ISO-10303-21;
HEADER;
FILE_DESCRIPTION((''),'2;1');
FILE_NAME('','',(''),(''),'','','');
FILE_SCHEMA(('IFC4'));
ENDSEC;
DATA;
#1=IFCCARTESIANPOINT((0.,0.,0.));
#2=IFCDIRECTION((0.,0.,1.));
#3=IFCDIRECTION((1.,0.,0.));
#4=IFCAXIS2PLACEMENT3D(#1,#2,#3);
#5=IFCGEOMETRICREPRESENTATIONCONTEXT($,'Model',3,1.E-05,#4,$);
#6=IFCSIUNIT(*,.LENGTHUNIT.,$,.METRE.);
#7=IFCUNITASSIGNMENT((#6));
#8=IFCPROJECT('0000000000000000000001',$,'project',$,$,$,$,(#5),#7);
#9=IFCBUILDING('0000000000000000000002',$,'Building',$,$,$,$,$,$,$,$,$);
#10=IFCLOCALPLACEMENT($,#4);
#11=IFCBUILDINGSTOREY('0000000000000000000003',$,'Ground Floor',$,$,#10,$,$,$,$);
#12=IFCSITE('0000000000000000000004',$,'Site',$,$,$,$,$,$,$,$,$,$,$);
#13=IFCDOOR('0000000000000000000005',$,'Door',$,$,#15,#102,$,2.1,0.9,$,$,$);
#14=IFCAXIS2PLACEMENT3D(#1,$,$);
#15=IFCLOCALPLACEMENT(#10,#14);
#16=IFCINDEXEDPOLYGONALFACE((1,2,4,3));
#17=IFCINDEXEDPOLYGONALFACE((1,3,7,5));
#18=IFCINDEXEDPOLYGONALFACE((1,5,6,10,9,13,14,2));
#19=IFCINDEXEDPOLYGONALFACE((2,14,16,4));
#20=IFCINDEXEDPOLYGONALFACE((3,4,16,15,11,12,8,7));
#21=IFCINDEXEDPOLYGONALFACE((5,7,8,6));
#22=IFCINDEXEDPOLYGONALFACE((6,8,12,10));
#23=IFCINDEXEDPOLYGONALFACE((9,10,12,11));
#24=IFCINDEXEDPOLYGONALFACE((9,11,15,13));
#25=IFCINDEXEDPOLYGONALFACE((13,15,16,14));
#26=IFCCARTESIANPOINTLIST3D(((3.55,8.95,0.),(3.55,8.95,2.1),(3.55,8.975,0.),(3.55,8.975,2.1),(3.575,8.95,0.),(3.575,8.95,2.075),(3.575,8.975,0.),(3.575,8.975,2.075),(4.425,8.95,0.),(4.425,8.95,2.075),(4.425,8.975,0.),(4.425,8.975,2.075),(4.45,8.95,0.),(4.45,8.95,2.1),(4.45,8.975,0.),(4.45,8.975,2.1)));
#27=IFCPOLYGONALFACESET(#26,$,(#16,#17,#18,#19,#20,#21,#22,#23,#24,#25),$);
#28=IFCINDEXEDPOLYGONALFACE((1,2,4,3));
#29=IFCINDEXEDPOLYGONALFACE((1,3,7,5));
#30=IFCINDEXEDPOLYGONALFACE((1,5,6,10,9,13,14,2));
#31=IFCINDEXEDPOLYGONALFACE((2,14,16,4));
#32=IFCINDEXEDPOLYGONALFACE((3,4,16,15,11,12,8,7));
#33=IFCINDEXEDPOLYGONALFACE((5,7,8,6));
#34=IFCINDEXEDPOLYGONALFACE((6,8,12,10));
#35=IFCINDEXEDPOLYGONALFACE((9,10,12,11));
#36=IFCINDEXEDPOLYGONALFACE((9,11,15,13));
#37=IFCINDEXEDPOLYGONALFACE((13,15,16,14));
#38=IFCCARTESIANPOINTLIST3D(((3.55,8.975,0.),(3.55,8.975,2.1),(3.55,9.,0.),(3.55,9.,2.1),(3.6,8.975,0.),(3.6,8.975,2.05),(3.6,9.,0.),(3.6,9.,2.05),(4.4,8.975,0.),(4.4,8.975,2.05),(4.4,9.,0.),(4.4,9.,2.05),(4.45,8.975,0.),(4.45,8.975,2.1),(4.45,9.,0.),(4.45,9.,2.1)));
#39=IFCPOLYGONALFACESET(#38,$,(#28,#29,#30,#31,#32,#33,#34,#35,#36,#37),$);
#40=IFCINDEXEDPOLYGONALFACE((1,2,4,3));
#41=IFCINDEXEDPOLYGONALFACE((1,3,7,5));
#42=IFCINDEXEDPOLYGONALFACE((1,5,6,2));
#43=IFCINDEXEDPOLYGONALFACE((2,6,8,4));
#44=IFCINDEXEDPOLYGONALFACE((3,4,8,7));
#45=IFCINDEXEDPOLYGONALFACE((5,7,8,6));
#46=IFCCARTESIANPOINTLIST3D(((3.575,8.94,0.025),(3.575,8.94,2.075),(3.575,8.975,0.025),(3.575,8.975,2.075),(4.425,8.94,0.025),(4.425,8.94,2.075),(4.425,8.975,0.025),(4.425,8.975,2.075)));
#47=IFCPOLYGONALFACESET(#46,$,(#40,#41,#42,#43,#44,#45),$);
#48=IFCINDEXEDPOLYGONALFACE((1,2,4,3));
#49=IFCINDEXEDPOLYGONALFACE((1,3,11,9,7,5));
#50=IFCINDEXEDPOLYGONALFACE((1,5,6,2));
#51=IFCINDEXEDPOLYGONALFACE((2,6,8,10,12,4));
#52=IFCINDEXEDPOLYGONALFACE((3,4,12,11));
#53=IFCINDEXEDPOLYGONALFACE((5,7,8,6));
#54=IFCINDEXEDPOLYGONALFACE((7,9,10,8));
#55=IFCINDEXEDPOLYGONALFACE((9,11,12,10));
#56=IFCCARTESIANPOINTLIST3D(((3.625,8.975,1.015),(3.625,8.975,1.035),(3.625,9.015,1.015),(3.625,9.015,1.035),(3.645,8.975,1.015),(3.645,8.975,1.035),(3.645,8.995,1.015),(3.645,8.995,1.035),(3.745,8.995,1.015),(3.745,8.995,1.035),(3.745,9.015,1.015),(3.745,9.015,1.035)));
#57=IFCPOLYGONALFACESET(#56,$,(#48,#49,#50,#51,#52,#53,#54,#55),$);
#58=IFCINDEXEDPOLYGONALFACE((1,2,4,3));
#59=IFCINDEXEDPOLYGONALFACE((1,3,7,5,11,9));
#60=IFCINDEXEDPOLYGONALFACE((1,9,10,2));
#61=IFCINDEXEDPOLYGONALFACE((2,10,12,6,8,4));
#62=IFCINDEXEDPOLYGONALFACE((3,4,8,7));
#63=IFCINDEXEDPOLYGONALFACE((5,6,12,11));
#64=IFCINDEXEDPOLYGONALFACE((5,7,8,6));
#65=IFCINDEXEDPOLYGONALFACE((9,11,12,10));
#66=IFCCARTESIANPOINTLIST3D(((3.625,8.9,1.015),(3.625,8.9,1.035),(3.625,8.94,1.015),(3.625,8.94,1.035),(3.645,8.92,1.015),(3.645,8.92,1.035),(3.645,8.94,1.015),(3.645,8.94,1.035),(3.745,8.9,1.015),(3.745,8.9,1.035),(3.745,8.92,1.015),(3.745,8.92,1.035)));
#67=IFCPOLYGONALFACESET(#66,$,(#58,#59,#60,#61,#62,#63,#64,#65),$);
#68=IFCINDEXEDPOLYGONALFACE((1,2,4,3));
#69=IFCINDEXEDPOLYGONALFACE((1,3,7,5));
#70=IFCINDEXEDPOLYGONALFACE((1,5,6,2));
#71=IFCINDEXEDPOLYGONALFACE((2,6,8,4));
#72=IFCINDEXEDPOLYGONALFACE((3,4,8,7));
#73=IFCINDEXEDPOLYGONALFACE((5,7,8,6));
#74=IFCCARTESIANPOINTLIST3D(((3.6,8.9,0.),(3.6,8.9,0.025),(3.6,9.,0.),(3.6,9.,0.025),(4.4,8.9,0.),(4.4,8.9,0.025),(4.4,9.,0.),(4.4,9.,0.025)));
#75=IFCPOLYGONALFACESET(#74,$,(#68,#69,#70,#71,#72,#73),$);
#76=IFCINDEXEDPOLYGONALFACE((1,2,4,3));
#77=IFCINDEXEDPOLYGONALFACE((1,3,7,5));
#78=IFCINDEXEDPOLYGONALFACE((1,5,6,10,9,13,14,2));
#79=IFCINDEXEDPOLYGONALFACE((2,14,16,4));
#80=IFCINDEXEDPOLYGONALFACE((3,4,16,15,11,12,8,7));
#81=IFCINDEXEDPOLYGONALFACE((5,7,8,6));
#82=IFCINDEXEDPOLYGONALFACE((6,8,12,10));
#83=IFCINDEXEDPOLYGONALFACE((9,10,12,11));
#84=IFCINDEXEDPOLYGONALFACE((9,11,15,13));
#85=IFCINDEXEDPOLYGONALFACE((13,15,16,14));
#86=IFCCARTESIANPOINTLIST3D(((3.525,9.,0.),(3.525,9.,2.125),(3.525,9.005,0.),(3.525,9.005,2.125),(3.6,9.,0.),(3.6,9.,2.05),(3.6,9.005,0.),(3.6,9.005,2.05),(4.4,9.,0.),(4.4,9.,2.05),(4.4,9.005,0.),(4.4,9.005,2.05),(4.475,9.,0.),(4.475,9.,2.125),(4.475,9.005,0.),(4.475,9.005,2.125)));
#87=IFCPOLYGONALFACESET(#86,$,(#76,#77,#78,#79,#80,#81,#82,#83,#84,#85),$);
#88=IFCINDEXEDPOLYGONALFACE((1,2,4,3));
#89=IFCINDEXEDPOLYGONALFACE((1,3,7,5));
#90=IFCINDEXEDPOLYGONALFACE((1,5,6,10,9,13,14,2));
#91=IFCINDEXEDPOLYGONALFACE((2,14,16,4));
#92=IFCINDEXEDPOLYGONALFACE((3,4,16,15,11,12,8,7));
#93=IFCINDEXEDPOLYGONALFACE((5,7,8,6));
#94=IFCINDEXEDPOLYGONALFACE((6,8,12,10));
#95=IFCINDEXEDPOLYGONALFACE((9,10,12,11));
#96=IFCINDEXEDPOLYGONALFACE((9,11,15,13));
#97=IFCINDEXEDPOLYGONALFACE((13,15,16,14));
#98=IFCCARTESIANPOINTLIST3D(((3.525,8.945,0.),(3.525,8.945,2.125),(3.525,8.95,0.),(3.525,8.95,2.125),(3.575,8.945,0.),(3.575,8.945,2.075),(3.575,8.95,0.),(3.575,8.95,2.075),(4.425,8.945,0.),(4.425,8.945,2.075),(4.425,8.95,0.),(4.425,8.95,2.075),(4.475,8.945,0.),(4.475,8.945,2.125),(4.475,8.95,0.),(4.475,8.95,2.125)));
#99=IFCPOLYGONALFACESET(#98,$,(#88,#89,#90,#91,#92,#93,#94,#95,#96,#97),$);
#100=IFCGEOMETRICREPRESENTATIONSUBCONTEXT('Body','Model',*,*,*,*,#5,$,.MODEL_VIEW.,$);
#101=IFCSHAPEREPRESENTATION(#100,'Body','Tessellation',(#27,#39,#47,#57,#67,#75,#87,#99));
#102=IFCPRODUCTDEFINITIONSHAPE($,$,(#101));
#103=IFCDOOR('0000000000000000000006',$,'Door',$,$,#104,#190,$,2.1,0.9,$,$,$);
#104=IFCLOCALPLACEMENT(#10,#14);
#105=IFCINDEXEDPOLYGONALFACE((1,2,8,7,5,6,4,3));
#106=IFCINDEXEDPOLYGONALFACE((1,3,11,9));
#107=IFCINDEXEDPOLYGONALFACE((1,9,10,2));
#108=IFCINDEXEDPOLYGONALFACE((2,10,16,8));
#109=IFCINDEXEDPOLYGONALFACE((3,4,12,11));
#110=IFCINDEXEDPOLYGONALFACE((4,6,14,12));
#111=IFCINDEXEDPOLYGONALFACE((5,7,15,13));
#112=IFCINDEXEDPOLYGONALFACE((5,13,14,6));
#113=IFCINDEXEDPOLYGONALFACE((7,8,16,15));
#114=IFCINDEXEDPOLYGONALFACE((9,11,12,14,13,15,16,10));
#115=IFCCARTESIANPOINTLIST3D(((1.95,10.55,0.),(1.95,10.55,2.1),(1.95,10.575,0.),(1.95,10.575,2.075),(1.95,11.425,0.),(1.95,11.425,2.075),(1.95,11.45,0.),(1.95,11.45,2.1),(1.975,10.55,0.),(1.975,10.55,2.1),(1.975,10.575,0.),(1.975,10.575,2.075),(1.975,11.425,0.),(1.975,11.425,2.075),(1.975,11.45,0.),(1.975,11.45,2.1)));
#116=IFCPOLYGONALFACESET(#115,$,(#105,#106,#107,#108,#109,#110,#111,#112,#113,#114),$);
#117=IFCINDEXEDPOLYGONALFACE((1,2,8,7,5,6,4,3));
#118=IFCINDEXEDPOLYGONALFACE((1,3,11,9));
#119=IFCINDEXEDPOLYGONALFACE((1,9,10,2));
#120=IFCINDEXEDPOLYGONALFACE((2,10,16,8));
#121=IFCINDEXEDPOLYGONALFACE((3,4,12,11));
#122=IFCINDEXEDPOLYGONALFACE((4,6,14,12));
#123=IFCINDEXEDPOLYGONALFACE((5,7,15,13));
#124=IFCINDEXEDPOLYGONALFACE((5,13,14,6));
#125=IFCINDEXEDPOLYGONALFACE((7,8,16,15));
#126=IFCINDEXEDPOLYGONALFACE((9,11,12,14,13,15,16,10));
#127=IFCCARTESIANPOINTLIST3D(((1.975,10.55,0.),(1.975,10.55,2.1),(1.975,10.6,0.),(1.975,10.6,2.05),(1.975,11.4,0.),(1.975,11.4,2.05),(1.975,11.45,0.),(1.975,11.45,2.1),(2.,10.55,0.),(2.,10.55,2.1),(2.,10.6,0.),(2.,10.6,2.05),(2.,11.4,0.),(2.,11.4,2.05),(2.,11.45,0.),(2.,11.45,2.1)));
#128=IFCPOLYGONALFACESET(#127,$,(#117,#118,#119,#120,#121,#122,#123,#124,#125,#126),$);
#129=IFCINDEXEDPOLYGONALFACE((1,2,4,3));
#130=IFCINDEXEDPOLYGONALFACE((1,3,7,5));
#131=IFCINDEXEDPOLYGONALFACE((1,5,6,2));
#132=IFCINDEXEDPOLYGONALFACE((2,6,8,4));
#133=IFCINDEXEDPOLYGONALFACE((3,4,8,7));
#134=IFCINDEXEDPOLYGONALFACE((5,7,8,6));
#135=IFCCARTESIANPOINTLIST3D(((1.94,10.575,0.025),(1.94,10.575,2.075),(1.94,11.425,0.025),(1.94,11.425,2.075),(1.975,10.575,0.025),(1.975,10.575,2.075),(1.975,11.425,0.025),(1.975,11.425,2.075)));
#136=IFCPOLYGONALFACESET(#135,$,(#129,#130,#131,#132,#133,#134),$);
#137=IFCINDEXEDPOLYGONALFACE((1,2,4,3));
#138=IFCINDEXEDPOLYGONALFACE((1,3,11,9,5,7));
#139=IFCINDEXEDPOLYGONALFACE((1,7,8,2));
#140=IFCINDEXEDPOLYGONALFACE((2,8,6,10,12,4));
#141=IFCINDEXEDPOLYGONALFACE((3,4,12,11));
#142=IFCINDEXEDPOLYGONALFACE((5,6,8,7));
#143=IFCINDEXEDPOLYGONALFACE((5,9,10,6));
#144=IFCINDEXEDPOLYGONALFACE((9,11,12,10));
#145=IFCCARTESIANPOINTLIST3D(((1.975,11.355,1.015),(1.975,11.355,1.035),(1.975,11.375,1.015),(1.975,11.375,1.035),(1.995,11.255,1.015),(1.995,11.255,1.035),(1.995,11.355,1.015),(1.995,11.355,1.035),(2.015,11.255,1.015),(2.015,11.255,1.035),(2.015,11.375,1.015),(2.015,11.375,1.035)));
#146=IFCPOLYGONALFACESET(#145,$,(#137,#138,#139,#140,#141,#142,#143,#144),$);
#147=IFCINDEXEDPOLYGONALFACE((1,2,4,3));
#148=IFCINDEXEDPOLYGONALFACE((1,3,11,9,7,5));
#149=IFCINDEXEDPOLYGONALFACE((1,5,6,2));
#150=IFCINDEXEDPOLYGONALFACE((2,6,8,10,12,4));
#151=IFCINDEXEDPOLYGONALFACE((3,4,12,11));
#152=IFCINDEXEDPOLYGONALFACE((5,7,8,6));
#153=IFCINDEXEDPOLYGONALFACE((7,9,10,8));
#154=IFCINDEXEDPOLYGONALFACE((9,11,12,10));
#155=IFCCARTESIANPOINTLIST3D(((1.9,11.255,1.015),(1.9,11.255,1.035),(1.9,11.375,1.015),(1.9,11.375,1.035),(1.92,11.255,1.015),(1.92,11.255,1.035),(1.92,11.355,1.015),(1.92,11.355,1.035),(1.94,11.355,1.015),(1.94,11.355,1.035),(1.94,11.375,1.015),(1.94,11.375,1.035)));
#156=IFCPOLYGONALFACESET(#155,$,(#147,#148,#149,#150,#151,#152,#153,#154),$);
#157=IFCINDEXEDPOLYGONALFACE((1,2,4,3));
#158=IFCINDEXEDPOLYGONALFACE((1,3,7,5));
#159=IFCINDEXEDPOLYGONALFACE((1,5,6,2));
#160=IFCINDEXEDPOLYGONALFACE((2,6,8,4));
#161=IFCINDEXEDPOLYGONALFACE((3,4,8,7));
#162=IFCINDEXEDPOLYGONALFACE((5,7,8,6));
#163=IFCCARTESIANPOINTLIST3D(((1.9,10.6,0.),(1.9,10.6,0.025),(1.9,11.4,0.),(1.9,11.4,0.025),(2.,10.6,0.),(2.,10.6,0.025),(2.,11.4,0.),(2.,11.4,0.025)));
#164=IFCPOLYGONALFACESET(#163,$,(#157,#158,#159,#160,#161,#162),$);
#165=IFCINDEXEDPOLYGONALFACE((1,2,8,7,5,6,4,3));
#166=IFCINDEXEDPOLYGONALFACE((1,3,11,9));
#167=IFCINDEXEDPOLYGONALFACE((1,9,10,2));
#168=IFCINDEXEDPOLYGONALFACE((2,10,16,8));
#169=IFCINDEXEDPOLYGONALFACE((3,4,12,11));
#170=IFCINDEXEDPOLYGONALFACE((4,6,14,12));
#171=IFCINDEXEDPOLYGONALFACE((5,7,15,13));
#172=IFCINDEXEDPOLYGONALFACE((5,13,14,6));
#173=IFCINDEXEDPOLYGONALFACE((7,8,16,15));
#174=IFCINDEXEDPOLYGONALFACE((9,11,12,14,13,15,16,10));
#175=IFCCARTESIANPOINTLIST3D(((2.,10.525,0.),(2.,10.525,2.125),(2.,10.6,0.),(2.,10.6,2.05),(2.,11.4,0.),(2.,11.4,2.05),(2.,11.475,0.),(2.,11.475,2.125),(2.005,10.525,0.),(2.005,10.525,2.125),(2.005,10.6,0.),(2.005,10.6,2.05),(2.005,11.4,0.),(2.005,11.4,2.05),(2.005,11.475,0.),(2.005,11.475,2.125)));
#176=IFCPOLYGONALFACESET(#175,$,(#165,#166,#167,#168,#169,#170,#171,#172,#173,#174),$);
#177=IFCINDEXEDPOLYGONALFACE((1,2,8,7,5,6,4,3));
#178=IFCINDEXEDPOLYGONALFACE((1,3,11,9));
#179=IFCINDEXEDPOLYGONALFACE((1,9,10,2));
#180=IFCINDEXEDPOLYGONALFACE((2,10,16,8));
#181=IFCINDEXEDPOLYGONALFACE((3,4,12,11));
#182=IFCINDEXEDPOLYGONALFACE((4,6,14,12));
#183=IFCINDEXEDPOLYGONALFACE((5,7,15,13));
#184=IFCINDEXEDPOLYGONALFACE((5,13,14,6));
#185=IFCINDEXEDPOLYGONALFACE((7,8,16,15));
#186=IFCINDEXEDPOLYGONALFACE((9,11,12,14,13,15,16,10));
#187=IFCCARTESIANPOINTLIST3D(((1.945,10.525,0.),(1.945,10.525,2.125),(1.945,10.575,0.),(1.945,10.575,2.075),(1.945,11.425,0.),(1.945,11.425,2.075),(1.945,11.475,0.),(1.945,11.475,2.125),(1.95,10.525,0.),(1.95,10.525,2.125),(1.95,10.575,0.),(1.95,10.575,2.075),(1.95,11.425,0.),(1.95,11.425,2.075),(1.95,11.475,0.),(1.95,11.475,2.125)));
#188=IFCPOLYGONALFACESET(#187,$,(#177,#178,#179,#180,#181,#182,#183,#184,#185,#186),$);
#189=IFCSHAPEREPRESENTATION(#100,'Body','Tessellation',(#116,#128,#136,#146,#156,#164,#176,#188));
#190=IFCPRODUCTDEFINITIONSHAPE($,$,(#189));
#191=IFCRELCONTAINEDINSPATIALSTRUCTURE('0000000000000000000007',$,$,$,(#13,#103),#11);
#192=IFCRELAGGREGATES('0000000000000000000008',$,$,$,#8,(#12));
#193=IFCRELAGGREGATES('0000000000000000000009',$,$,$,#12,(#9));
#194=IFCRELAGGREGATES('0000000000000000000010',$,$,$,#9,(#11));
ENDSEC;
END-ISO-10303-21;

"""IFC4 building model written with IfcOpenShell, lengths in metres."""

from ifc_helpers import new_model, si_unit, frame, origin_with_axes, place, context, subcontext, project, spatial, line, indexed_curve, outline, extrude, element, save


model = new_model("IFC4")

# Units and contexts
model_context = context("Model", 3, precision=1e-05, world=origin_with_axes())
body_context = subcontext(model_context, "Body", "Model", "MODEL_VIEW")
ifc_project = project(units=[si_unit("LENGTHUNIT", "METRE")], contexts=[model_context])

# Site, building, storey
site = spatial("IfcSite", under=ifc_project, Name="Site")
building = spatial("IfcBuilding", under=site, Name="Building")
storey_placement = place(None, origin_with_axes())
storey = spatial("IfcBuildingStorey", under=building, at=storey_placement, Name="Ground Floor")

# Doors
door_1_placement = place(storey_placement, frame((4.45, 9.0, 0.0), z_axis=(0.0, 0.0, 1.0), x_axis=(-1.0, 0.0, 0.0)))
element("IfcDoor", 1, at=door_1_placement, inside=storey, Name="Door", OverallHeight=2.1, OverallWidth=0.9, context=body_context, shape_type="SweptSolid", body=[
    extrude(outline(indexed_curve([(0.0, 0.0), (0.0, 2.1), (0.9, 2.1), (0.9, 0.0), (0.875, 0.0), (0.875, 2.075), (0.025, 2.075), (0.025, 0.0)], segments=[line(1, 2, 3, 4, 5, 6, 7, 8, 1)])), frame((0.0, 0.025, 0.0), z_axis=(0.0, -1.0, 0.0), x_axis=(1.0, 0.0, 0.0)), (0.0, 0.0, -1.0), 0.025),
    extrude(outline(indexed_curve([(0.0, 0.0), (0.0, 2.1), (0.9, 2.1), (0.9, 0.0), (0.85, 0.0), (0.85, 2.05), (0.05, 2.05), (0.05, 0.0)], segments=[line(1, 2, 3, 4, 5, 6, 7, 8, 1)])), frame((0.0, 0.0, 0.0), z_axis=(0.0, -1.0, 0.0), x_axis=(1.0, 0.0, 0.0)), (0.0, 0.0, -1.0), 0.025),
    extrude(outline(indexed_curve([(0.0, 0.0), (0.85, 0.0), (0.85, 0.035), (0.0, 0.035)], segments=[line(1, 2, 3, 4, 1)])), frame((0.025, 0.025, 0.025), z_axis=(0.0, 0.0, 1.0), x_axis=(1.0, 0.0, 0.0)), (0.0, 0.0, 1.0), 2.05),
    extrude(outline(indexed_curve([(0.0, 0.0), (0.0, -0.04), (-0.12, -0.04), (-0.12, -0.02), (-0.02, -0.02), (-0.02, 0.0)], segments=[line(1, 2, 3, 4, 5, 6, 1)])), frame((0.825, 0.025, 1.015), z_axis=(0.0, 0.0, 1.0), x_axis=(1.0, 0.0, 0.0)), (0.0, 0.0, 1.0), 0.02),
    extrude(outline(indexed_curve([(0.0, 0.0), (0.0, 0.04), (-0.12, 0.04), (-0.12, 0.02), (-0.02, 0.02), (-0.02, 0.0)], segments=[line(1, 2, 3, 4, 5, 6, 1)])), frame((0.825, 0.06, 1.015), z_axis=(0.0, 0.0, 1.0), x_axis=(1.0, 0.0, 0.0)), (0.0, 0.0, 1.0), 0.02),
    extrude(outline(indexed_curve([(0.0, 0.0), (0.8, 0.0), (0.8, 0.1), (0.0, 0.1)], segments=[line(1, 2, 3, 4, 1)])), frame((0.05, 0.0, 0.0), z_axis=(0.0, 0.0, 1.0), x_axis=(1.0, 0.0, 0.0)), (0.0, 0.0, 1.0), 0.025),
    extrude(outline(indexed_curve([(0.0, 0.0), (0.0, 2.125), (0.95, 2.125), (0.95, 0.0), (0.875, 0.0), (0.875, 2.05), (0.075, 2.05), (0.075, 0.0)], segments=[line(1, 2, 3, 4, 5, 6, 7, 8, 1)])), frame((-0.025, -0.005, 0.0), z_axis=(0.0, -1.0, 0.0), x_axis=(1.0, 0.0, 0.0)), (0.0, 0.0, -1.0), 0.005),
    extrude(outline(indexed_curve([(0.0, 0.0), (0.0, 2.125), (0.95, 2.125), (0.95, 0.0), (0.9, 0.0), (0.9, 2.075), (0.05, 2.075), (0.05, 0.0)], segments=[line(1, 2, 3, 4, 5, 6, 7, 8, 1)])), frame((-0.025, 0.05, 0.0), z_axis=(0.0, -1.0, 0.0), x_axis=(1.0, 0.0, 0.0)), (0.0, 0.0, -1.0), 0.005),
])
door_2_placement = place(storey_placement, frame((2.0, 10.55, 0.0), z_axis=(0.0, 0.0, 1.0), x_axis=(0.0, 1.0, 0.0)))
element("IfcDoor", 2, at=door_2_placement, inside=storey, Name="Door", OverallHeight=2.1, OverallWidth=0.9, context=body_context, shape_type="SweptSolid", body=[
    extrude(outline(indexed_curve([(0.0, 0.0), (0.0, 2.1), (0.9, 2.1), (0.9, 0.0), (0.875, 0.0), (0.875, 2.075), (0.025, 2.075), (0.025, 0.0)], segments=[line(1, 2, 3, 4, 5, 6, 7, 8, 1)])), frame((0.0, 0.025, 0.0), z_axis=(0.0, -1.0, 0.0), x_axis=(1.0, 0.0, 0.0)), (0.0, 0.0, -1.0), 0.025),
    extrude(outline(indexed_curve([(0.0, 0.0), (0.0, 2.1), (0.9, 2.1), (0.9, 0.0), (0.85, 0.0), (0.85, 2.05), (0.05, 2.05), (0.05, 0.0)], segments=[line(1, 2, 3, 4, 5, 6, 7, 8, 1)])), frame((0.0, 0.0, 0.0), z_axis=(0.0, -1.0, 0.0), x_axis=(1.0, 0.0, 0.0)), (0.0, 0.0, -1.0), 0.025),
    extrude(outline(indexed_curve([(0.0, 0.0), (0.85, 0.0), (0.85, 0.035), (0.0, 0.035)], segments=[line(1, 2, 3, 4, 1)])), frame((0.025, 0.025, 0.025), z_axis=(0.0, 0.0, 1.0), x_axis=(1.0, 0.0, 0.0)), (0.0, 0.0, 1.0), 2.05),
    extrude(outline(indexed_curve([(0.0, 0.0), (0.0, -0.04), (-0.12, -0.04), (-0.12, -0.02), (-0.02, -0.02), (-0.02, 0.0)], segments=[line(1, 2, 3, 4, 5, 6, 1)])), frame((0.825, 0.025, 1.015), z_axis=(0.0, 0.0, 1.0), x_axis=(1.0, 0.0, 0.0)), (0.0, 0.0, 1.0), 0.02),
    extrude(outline(indexed_curve([(0.0, 0.0), (0.0, 0.04), (-0.12, 0.04), (-0.12, 0.02), (-0.02, 0.02), (-0.02, 0.0)], segments=[line(1, 2, 3, 4, 5, 6, 1)])), frame((0.825, 0.06, 1.015), z_axis=(0.0, 0.0, 1.0), x_axis=(1.0, 0.0, 0.0)), (0.0, 0.0, 1.0), 0.02),
    extrude(outline(indexed_curve([(0.0, 0.0), (0.8, 0.0), (0.8, 0.1), (0.0, 0.1)], segments=[line(1, 2, 3, 4, 1)])), frame((0.05, 0.0, 0.0), z_axis=(0.0, 0.0, 1.0), x_axis=(1.0, 0.0, 0.0)), (0.0, 0.0, 1.0), 0.025),
    extrude(outline(indexed_curve([(0.0, 0.0), (0.0, 2.125), (0.95, 2.125), (0.95, 0.0), (0.875, 0.0), (0.875, 2.05), (0.075, 2.05), (0.075, 0.0)], segments=[line(1, 2, 3, 4, 5, 6, 7, 8, 1)])), frame((-0.025, -0.005, 0.0), z_axis=(0.0, -1.0, 0.0), x_axis=(1.0, 0.0, 0.0)), (0.0, 0.0, -1.0), 0.005),
    extrude(outline(indexed_curve([(0.0, 0.0), (0.0, 2.125), (0.95, 2.125), (0.95, 0.0), (0.9, 0.0), (0.9, 2.075), (0.05, 2.075), (0.05, 0.0)], segments=[line(1, 2, 3, 4, 5, 6, 7, 8, 1)])), frame((-0.025, 0.05, 0.0), z_axis=(0.0, -1.0, 0.0), x_axis=(1.0, 0.0, 0.0)), (0.0, 0.0, -1.0), 0.005),
])

save(model, "model.ifc")
